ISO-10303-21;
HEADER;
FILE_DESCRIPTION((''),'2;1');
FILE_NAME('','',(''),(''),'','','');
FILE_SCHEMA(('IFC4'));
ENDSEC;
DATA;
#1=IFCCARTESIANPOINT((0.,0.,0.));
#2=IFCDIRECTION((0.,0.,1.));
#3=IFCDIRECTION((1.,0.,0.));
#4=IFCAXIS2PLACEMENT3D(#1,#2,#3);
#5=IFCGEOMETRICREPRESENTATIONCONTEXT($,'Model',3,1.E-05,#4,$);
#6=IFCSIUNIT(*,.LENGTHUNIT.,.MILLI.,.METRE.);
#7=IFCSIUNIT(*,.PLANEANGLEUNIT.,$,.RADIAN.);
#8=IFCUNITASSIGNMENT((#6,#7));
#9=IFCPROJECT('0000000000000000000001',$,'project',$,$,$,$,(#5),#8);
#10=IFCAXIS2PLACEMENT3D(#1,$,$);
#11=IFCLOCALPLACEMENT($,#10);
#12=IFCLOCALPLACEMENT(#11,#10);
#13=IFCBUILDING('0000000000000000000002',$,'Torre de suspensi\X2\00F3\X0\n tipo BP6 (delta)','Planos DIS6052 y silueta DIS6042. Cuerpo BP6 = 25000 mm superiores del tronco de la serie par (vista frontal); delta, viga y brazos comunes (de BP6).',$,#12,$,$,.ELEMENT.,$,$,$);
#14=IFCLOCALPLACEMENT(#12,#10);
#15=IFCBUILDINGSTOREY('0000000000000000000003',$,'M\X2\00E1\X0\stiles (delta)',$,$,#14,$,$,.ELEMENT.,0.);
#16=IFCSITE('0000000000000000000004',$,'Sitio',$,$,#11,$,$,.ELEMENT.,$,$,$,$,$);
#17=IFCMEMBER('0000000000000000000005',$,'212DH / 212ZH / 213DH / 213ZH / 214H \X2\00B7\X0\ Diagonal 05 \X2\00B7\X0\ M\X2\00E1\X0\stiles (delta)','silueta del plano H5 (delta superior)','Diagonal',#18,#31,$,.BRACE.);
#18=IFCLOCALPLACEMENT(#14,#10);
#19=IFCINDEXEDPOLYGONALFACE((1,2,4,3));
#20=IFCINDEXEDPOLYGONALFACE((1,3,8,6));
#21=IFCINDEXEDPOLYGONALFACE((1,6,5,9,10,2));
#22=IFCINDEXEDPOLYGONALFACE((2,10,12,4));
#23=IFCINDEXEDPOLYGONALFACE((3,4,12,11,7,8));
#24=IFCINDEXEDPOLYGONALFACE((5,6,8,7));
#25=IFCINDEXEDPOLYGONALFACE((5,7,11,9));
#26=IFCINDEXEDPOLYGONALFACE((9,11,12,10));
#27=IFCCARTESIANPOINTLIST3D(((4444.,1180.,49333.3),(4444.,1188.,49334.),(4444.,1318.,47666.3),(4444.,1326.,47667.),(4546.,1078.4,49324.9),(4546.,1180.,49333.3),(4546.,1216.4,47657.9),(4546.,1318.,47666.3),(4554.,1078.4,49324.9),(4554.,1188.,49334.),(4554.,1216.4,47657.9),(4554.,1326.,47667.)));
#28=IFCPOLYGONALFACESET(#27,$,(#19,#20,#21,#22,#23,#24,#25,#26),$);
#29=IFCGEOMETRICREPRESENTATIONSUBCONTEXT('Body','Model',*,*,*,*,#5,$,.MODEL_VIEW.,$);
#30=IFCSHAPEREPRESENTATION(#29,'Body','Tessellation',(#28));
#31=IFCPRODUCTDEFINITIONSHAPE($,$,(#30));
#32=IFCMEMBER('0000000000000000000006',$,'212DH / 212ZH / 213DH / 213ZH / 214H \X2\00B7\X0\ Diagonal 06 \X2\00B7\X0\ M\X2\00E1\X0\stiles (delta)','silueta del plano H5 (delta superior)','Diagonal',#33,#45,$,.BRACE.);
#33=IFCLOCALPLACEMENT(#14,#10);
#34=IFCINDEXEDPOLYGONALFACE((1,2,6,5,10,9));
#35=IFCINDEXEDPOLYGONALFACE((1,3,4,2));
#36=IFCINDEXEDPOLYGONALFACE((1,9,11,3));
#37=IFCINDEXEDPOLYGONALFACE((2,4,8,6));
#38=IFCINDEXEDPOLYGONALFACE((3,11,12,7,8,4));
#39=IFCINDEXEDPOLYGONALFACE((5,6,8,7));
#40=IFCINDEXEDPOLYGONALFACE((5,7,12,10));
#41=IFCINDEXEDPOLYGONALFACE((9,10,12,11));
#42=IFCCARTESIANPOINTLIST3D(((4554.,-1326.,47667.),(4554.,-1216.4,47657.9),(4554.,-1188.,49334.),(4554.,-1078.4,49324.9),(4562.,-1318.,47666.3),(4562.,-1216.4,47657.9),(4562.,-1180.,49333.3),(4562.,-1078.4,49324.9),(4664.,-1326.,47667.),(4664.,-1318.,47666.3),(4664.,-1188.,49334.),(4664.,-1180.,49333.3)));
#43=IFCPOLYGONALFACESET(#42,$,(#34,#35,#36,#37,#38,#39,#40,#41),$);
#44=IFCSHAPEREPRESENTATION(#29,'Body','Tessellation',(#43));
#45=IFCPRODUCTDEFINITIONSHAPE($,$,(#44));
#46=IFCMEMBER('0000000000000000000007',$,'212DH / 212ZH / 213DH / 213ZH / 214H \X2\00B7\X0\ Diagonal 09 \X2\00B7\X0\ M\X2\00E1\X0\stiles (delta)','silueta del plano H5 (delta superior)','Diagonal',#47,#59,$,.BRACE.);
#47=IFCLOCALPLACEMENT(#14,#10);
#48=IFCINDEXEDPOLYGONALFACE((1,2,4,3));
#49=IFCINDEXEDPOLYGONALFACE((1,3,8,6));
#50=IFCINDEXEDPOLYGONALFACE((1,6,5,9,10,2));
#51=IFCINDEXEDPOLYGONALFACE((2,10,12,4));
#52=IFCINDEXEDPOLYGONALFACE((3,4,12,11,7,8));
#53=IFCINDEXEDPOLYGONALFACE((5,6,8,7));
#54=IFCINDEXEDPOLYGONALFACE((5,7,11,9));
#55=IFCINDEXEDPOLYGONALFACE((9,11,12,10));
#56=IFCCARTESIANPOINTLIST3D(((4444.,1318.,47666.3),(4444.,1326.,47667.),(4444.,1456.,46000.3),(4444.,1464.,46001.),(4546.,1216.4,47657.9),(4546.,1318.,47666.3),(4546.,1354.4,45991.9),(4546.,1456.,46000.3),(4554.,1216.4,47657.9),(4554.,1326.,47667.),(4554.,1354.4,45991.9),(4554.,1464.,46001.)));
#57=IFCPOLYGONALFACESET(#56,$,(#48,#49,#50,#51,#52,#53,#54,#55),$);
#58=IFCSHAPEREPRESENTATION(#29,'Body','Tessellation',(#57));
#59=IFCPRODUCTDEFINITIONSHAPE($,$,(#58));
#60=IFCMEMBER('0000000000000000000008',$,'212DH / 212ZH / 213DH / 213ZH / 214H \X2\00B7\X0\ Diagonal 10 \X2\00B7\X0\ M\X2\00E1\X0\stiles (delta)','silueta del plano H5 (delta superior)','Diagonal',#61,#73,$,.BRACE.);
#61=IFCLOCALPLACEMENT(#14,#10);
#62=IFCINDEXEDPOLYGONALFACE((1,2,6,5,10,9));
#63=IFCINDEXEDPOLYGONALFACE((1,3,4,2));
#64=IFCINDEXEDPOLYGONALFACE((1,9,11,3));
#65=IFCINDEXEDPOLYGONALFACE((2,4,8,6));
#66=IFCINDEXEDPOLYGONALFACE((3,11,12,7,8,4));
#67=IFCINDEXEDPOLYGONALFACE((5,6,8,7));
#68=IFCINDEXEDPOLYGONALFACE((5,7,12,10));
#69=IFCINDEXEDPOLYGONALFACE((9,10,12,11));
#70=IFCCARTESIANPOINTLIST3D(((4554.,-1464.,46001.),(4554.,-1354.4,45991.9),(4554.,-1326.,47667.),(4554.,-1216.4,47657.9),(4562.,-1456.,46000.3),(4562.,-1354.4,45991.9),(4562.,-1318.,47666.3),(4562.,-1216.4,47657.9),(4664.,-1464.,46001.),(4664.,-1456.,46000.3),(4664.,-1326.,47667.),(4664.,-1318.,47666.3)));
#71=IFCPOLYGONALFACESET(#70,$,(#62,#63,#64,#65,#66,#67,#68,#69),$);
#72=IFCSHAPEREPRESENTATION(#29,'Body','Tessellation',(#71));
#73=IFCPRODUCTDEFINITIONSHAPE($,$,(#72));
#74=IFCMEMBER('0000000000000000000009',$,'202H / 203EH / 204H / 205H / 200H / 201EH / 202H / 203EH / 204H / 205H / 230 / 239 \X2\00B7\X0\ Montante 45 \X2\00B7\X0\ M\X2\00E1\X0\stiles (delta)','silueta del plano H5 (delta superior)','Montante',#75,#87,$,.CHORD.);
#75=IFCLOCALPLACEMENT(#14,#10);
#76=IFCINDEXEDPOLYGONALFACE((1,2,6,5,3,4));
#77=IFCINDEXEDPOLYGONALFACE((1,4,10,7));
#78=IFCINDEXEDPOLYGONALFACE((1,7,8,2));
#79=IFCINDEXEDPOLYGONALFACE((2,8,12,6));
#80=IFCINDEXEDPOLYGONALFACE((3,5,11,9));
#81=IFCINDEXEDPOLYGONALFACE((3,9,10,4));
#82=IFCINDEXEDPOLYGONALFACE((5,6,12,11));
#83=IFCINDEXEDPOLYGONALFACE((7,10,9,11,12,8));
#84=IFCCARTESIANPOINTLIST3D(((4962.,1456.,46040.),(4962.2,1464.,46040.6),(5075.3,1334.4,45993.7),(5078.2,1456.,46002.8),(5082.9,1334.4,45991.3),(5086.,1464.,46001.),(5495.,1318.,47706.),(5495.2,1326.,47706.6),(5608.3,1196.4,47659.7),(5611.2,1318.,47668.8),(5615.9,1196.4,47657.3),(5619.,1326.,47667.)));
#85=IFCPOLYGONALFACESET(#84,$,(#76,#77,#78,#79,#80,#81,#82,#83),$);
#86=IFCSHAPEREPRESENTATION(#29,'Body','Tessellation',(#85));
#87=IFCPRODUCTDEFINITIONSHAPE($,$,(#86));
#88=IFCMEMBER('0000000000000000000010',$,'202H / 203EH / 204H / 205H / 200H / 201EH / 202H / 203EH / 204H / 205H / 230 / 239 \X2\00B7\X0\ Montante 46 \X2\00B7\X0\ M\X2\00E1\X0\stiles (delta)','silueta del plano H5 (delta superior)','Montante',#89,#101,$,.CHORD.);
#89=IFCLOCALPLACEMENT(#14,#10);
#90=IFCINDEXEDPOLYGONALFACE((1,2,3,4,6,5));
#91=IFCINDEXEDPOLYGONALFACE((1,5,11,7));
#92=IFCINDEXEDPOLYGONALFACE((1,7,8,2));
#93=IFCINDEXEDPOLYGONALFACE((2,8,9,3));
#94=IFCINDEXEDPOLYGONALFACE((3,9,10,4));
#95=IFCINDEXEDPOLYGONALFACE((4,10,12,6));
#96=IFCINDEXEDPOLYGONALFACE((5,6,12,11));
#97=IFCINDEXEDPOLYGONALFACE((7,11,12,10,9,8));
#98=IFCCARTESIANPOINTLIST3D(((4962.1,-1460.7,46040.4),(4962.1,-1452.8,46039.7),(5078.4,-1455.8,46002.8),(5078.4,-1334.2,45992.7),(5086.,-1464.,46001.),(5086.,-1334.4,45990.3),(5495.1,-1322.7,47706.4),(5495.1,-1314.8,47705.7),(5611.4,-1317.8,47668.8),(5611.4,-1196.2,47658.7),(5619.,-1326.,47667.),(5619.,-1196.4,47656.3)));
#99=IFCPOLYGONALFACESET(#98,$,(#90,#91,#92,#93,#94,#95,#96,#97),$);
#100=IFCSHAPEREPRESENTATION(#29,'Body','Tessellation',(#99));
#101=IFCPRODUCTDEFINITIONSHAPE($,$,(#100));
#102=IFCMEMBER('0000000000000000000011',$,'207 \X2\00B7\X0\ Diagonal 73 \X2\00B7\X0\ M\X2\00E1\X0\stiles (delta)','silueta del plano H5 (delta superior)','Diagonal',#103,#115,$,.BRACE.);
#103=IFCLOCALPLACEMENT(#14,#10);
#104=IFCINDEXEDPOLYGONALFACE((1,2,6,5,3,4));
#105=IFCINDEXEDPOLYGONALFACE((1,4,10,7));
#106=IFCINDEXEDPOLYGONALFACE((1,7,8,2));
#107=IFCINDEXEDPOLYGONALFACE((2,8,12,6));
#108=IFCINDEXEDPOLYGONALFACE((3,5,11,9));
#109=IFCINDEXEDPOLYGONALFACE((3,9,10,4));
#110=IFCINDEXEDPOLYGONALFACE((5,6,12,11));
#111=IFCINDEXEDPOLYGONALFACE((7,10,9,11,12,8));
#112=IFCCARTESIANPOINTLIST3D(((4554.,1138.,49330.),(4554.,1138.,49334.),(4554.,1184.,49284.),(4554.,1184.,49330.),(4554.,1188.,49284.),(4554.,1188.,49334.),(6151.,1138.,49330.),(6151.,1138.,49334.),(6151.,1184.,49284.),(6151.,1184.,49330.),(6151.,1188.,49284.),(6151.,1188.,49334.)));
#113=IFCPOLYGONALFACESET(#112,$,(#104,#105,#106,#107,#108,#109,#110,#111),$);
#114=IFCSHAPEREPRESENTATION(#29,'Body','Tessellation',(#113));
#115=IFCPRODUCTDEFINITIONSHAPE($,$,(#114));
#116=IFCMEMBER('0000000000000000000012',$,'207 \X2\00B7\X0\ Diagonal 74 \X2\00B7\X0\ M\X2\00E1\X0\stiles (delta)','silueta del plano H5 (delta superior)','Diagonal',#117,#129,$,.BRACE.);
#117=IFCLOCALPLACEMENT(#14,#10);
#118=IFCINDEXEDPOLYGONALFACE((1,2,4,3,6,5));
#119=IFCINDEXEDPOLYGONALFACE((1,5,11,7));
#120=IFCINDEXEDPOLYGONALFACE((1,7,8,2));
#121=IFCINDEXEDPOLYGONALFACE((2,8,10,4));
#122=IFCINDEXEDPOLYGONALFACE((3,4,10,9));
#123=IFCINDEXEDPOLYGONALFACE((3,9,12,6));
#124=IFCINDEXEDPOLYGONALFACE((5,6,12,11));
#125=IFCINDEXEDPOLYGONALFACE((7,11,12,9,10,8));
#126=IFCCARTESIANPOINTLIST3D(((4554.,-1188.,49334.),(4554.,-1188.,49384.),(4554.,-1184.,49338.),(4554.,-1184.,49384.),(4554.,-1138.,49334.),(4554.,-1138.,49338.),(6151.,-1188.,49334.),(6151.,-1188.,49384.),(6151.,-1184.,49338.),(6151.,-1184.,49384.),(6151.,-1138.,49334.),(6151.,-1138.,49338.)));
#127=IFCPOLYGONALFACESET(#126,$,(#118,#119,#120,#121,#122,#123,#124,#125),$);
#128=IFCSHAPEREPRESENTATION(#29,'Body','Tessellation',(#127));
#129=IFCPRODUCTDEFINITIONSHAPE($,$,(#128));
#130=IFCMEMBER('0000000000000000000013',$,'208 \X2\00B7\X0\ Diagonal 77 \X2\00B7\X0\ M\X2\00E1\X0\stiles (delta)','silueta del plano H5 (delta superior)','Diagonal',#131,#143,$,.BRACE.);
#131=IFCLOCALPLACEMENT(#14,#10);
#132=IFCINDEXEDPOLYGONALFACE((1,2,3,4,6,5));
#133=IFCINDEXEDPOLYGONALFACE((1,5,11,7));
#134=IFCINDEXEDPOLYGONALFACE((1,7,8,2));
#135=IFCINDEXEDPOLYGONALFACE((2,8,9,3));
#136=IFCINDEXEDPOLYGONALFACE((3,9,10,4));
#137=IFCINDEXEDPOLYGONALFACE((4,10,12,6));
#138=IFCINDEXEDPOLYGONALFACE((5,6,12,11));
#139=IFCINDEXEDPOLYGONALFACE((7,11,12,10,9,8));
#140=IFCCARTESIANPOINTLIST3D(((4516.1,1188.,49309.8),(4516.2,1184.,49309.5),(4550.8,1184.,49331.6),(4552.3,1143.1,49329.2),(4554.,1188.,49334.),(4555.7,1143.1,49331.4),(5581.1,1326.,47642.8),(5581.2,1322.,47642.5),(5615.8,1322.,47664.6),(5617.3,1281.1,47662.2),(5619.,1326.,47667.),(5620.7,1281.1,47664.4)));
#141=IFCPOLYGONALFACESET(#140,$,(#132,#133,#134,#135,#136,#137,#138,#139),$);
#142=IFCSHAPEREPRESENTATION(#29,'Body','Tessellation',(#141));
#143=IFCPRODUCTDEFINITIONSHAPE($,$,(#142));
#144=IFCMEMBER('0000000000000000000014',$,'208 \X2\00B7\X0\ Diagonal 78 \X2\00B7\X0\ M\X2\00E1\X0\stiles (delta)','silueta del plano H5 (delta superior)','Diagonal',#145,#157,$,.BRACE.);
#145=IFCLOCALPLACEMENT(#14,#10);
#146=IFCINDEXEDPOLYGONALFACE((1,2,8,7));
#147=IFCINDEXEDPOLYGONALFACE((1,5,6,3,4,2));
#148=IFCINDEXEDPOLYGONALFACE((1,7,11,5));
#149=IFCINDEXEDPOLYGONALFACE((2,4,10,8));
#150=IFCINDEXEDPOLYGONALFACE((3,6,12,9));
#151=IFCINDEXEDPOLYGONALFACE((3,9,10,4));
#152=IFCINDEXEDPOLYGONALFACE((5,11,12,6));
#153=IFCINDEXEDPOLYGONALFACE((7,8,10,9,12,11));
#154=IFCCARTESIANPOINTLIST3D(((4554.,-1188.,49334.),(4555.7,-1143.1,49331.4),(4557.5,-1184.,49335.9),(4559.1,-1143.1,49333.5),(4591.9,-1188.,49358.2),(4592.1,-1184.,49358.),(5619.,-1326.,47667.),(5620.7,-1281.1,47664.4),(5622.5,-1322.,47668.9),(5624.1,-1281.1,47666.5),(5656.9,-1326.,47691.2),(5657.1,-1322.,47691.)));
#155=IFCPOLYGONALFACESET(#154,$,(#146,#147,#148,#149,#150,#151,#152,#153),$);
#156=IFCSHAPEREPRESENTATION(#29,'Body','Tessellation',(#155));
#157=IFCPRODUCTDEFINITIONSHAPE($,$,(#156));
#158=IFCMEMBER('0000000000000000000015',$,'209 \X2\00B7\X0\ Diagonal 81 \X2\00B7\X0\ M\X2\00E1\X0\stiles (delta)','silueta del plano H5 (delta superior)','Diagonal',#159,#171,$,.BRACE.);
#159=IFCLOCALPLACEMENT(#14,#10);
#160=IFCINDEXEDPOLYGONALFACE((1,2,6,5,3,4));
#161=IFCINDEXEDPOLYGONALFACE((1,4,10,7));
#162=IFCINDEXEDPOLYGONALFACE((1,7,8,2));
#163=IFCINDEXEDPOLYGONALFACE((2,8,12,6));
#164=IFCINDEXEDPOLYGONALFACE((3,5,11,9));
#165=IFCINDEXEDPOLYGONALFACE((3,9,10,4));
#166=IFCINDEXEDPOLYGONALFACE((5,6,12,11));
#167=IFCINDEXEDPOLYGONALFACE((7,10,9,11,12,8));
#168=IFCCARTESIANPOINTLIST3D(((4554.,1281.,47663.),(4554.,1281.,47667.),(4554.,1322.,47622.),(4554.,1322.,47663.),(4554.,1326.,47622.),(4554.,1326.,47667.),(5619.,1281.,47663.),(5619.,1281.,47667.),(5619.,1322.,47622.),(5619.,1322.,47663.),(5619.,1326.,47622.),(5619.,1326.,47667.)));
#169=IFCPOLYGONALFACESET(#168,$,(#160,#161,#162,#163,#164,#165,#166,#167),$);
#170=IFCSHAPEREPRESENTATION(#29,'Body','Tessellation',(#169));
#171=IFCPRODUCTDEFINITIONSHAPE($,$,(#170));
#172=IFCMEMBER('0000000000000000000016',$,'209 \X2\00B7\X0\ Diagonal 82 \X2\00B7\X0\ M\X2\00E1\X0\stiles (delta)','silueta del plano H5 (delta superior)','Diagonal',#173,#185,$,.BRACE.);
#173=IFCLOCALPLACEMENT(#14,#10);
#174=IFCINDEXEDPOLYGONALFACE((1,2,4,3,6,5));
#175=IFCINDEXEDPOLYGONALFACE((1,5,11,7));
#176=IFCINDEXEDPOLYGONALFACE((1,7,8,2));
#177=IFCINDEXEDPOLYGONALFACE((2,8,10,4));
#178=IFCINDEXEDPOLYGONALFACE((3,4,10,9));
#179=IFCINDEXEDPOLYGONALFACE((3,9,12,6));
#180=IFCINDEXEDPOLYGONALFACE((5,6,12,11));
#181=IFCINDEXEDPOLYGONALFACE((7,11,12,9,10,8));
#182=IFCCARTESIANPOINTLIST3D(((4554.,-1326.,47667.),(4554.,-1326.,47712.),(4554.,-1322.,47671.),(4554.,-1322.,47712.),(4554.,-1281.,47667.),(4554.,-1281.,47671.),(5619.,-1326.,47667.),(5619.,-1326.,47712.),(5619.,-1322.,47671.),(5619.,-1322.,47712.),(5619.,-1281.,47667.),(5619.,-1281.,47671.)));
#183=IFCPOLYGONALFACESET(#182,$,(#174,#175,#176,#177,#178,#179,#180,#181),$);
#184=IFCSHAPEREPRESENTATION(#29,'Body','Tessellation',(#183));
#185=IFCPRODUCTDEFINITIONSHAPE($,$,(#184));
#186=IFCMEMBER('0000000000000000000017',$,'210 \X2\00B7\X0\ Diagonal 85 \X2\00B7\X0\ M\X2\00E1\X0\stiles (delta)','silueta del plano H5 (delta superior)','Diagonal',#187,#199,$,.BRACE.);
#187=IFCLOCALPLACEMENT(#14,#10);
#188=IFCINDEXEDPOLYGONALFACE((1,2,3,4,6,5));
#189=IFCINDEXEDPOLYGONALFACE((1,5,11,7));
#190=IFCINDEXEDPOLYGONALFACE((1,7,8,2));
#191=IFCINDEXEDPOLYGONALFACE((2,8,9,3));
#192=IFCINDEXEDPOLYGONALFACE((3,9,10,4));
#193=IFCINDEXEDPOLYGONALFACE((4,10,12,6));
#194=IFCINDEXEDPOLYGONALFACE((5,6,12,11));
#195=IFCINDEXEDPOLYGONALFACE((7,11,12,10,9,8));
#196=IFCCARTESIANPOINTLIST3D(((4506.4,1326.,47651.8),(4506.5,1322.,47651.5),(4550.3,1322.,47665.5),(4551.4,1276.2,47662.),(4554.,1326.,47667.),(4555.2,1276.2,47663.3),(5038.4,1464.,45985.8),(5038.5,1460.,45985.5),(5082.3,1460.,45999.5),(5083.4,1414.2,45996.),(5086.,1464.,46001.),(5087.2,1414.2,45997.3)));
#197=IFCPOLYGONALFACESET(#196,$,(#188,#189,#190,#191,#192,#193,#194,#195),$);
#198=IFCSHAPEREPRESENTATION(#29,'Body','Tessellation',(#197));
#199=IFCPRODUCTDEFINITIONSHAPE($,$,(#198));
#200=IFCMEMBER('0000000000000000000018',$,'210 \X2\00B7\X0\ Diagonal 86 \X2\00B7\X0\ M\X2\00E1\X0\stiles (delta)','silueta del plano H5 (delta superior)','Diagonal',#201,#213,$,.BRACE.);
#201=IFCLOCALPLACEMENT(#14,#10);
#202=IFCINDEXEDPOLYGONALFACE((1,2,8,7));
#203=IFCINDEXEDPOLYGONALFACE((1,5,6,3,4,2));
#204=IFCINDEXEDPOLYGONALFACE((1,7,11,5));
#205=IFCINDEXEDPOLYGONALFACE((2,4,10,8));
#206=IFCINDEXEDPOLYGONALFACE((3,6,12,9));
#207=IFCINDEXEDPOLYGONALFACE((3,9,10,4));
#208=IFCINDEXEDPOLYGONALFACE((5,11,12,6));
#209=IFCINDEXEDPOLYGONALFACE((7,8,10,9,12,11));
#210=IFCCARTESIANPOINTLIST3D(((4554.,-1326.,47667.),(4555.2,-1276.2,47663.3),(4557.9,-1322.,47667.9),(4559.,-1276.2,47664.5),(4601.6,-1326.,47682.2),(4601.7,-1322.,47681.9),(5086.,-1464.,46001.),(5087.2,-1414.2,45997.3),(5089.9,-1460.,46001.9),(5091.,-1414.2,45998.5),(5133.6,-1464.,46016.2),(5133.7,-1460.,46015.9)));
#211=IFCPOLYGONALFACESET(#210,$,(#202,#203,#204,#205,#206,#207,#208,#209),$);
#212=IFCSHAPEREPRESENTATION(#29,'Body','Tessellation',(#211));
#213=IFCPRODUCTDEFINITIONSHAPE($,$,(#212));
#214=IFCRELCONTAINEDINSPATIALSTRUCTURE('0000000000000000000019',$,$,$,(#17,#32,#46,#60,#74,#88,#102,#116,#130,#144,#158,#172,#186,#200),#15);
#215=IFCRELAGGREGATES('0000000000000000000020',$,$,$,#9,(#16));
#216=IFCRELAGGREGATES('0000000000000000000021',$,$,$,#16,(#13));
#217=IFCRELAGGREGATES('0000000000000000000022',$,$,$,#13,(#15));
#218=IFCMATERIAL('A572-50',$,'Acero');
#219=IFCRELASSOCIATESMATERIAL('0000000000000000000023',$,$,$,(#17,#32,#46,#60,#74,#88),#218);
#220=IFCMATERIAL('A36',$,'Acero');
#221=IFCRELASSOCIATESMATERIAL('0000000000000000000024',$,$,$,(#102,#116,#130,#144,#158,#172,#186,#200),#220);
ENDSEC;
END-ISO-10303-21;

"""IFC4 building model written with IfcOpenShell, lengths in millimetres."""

from ifc_helpers import new_model, si_unit, frame, frame_2d, origin, origin_with_axes, place, context, subcontext, project, spatial, l_section, extrude, material, element, save


model = new_model("IFC4")

# Units and contexts
model_context = context("Model", 3, precision=1e-05, world=origin_with_axes())
body_context = subcontext(model_context, "Body", "Model", "MODEL_VIEW")
ifc_project = project(units=[si_unit("LENGTHUNIT", "METRE", prefix="MILLI"), si_unit("PLANEANGLEUNIT", "RADIAN")], contexts=[model_context])

# Site, building, storey
site_placement = place(None, origin())
site = spatial("IfcSite", under=ifc_project, at=site_placement, Name="Sitio", CompositionType="ELEMENT")
building_placement = place(site_placement, origin())
building = spatial("IfcBuilding", under=site, at=building_placement, Name="Torre de suspensión tipo BP6 (delta)", Description="Planos DIS6052 y silueta DIS6042. Cuerpo BP6 = 25000 mm superiores del tronco de la serie par (vista frontal); delta, viga y brazos comunes (de BP6).", CompositionType="ELEMENT")
storey_placement = place(building_placement, origin())
storey = spatial("IfcBuildingStorey", under=building, at=storey_placement, Name="Mástiles (delta)", CompositionType="ELEMENT", Elevation=0.0)

# Members
ifc_material_1 = material(Name="A572-50", Category="Acero")
for number, where, z_axis, x_axis, name in (
    (1, (4554.0, 1188.0, 49334.0), (0.0, 0.082501, -0.996591), (0.0, -0.996591, -0.082501), "212DH / 212ZH / 213DH / 213ZH / 214H · Diagonal 05 · Mástiles (delta)"),
    (2, (4554.0, -1188.0, 49334.0), (0.0, -0.082501, -0.996591), (0.0, 0.996591, -0.082501), "212DH / 212ZH / 213DH / 213ZH / 214H · Diagonal 06 · Mástiles (delta)"),
):
    element("IfcMember", number, at=place(storey_placement, frame(where, z_axis=z_axis, x_axis=x_axis)), inside=storey, material=ifc_material_1, Name=name, Description="silueta del plano H5 (delta superior)", ObjectType="Diagonal", PredefinedType="BRACE", context=body_context, shape_type="SweptSolid", body=[
        extrude(l_section(Depth=110.0, Width=110.0, Thickness=8.0, at=frame_2d((55.0, 55.0))), None, (0.0, 0.0, 1.0), 1672.7),
    ])
for number, where, z_axis, x_axis, name in (
    (3, (4554.0, 1326.0, 47667.0), (0.0, 0.08255, -0.996587), (0.0, -0.996587, -0.08255), "212DH / 212ZH / 213DH / 213ZH / 214H · Diagonal 09 · Mástiles (delta)"),
    (4, (4554.0, -1326.0, 47667.0), (0.0, -0.08255, -0.996587), (0.0, 0.996587, -0.08255), "212DH / 212ZH / 213DH / 213ZH / 214H · Diagonal 10 · Mástiles (delta)"),
):
    element("IfcMember", number, at=place(storey_placement, frame(where, z_axis=z_axis, x_axis=x_axis)), inside=storey, material=ifc_material_1, Name=name, Description="silueta del plano H5 (delta superior)", ObjectType="Diagonal", PredefinedType="BRACE", context=body_context, shape_type="SweptSolid", body=[
        extrude(l_section(Depth=110.0, Width=110.0, Thickness=8.0, at=frame_2d((55.0, 55.0))), None, (0.0, 0.0, 1.0), 1671.7),
    ])
for number, where, z_axis, x_axis, name in (
    (5, (5619.0, 1326.0, 47667.0), (-0.30377, 0.07865, -0.949494), (-0.023966, -0.996902, -0.074909), "202H / 203EH / 204H / 205H / 200H / 201EH / 202H / 203EH / 204H / 205H / 230 / 239 · Montante 45 · Mástiles (delta)"),
    (6, (5619.0, -1326.0, 47667.0), (-0.30377, -0.07865, -0.949494), (-0.952746, 0.025076, 0.302733), "202H / 203EH / 204H / 205H / 200H / 201EH / 202H / 203EH / 204H / 205H / 230 / 239 · Montante 46 · Mástiles (delta)"),
):
    element("IfcMember", number, at=place(storey_placement, frame(where, z_axis=z_axis, x_axis=x_axis)), inside=storey, material=ifc_material_1, Name=name, Description="silueta del plano H5 (delta superior)", ObjectType="Montante", PredefinedType="CHORD", context=body_context, shape_type="SweptSolid", body=[
        extrude(l_section(Depth=130.0, Width=130.0, Thickness=8.0, at=frame_2d((65.0, 65.0))), None, (0.0, 0.0, 1.0), 1754.6),
    ])
ifc_material_2 = material(Name="A36", Category="Acero")
for number, where, z_axis, x_axis, name in (
    (7, (4554.0, 1188.0, 49334.0), (1.0, 0.0, 0.0), (0.0, -1.0, 0.0), "207 · Diagonal 73 · Mástiles (delta)"),
    (8, (4554.0, -1188.0, 49334.0), (1.0, 0.0, 0.0), (0.0, 1.0, 0.0), "207 · Diagonal 74 · Mástiles (delta)"),
):
    element("IfcMember", number, at=place(storey_placement, frame(where, z_axis=z_axis, x_axis=x_axis)), inside=storey, material=ifc_material_2, Name=name, Description="silueta del plano H5 (delta superior)", ObjectType="Diagonal", PredefinedType="BRACE", context=body_context, shape_type="SweptSolid", body=[
        extrude(l_section(Depth=50.0, Width=50.0, Thickness=4.0, at=frame_2d((25.0, 25.0))), None, (0.0, 0.0, 1.0), 1597.0),
    ])
for number, where, z_axis, x_axis, name in (
    (9, (4554.0, 1188.0, 49334.0), (0.537074, 0.069593, -0.840659), (0.037467, -0.997575, -0.058646), "208 · Diagonal 77 · Mástiles (delta)"),
    (10, (4554.0, -1188.0, 49334.0), (0.537074, -0.069593, -0.840659), (0.037467, 0.997575, -0.058646), "208 · Diagonal 78 · Mástiles (delta)"),
):
    element("IfcMember", number, at=place(storey_placement, frame(where, z_axis=z_axis, x_axis=x_axis)), inside=storey, material=ifc_material_2, Name=name, Description="silueta del plano H5 (delta superior)", ObjectType="Diagonal", PredefinedType="BRACE", context=body_context, shape_type="SweptSolid", body=[
        extrude(l_section(Depth=45.0, Width=45.0, Thickness=4.0, at=frame_2d((22.5, 22.5))), None, (0.0, 0.0, 1.0), 1983.0),
    ])
for number, where, z_axis, x_axis, name in (
    (11, (4554.0, 1326.0, 47667.0), (1.0, 0.0, 0.0), (0.0, -1.0, 0.0), "209 · Diagonal 81 · Mástiles (delta)"),
    (12, (4554.0, -1326.0, 47667.0), (1.0, 0.0, 0.0), (0.0, 1.0, 0.0), "209 · Diagonal 82 · Mástiles (delta)"),
):
    element("IfcMember", number, at=place(storey_placement, frame(where, z_axis=z_axis, x_axis=x_axis)), inside=storey, material=ifc_material_2, Name=name, Description="silueta del plano H5 (delta superior)", ObjectType="Diagonal", PredefinedType="BRACE", context=body_context, shape_type="SweptSolid", body=[
        extrude(l_section(Depth=45.0, Width=45.0, Thickness=4.0, at=frame_2d((22.5, 22.5))), None, (0.0, 0.0, 1.0), 1065.0),
    ])
for number, where, z_axis, x_axis, name in (
    (13, (4554.0, 1326.0, 47667.0), (0.303252, 0.078663, -0.949658), (0.023929, -0.996901, -0.074935), "210 · Diagonal 85 · Mástiles (delta)"),
    (14, (4554.0, -1326.0, 47667.0), (0.303252, -0.078663, -0.949658), (0.023929, 0.996901, -0.074935), "210 · Diagonal 86 · Mástiles (delta)"),
):
    element("IfcMember", number, at=place(storey_placement, frame(where, z_axis=z_axis, x_axis=x_axis)), inside=storey, material=ifc_material_2, Name=name, Description="silueta del plano H5 (delta superior)", ObjectType="Diagonal", PredefinedType="BRACE", context=body_context, shape_type="SweptSolid", body=[
        extrude(l_section(Depth=50.0, Width=50.0, Thickness=4.0, at=frame_2d((25.0, 25.0))), None, (0.0, 0.0, 1.0), 1754.3),
    ])

save(model, "model.ifc")
